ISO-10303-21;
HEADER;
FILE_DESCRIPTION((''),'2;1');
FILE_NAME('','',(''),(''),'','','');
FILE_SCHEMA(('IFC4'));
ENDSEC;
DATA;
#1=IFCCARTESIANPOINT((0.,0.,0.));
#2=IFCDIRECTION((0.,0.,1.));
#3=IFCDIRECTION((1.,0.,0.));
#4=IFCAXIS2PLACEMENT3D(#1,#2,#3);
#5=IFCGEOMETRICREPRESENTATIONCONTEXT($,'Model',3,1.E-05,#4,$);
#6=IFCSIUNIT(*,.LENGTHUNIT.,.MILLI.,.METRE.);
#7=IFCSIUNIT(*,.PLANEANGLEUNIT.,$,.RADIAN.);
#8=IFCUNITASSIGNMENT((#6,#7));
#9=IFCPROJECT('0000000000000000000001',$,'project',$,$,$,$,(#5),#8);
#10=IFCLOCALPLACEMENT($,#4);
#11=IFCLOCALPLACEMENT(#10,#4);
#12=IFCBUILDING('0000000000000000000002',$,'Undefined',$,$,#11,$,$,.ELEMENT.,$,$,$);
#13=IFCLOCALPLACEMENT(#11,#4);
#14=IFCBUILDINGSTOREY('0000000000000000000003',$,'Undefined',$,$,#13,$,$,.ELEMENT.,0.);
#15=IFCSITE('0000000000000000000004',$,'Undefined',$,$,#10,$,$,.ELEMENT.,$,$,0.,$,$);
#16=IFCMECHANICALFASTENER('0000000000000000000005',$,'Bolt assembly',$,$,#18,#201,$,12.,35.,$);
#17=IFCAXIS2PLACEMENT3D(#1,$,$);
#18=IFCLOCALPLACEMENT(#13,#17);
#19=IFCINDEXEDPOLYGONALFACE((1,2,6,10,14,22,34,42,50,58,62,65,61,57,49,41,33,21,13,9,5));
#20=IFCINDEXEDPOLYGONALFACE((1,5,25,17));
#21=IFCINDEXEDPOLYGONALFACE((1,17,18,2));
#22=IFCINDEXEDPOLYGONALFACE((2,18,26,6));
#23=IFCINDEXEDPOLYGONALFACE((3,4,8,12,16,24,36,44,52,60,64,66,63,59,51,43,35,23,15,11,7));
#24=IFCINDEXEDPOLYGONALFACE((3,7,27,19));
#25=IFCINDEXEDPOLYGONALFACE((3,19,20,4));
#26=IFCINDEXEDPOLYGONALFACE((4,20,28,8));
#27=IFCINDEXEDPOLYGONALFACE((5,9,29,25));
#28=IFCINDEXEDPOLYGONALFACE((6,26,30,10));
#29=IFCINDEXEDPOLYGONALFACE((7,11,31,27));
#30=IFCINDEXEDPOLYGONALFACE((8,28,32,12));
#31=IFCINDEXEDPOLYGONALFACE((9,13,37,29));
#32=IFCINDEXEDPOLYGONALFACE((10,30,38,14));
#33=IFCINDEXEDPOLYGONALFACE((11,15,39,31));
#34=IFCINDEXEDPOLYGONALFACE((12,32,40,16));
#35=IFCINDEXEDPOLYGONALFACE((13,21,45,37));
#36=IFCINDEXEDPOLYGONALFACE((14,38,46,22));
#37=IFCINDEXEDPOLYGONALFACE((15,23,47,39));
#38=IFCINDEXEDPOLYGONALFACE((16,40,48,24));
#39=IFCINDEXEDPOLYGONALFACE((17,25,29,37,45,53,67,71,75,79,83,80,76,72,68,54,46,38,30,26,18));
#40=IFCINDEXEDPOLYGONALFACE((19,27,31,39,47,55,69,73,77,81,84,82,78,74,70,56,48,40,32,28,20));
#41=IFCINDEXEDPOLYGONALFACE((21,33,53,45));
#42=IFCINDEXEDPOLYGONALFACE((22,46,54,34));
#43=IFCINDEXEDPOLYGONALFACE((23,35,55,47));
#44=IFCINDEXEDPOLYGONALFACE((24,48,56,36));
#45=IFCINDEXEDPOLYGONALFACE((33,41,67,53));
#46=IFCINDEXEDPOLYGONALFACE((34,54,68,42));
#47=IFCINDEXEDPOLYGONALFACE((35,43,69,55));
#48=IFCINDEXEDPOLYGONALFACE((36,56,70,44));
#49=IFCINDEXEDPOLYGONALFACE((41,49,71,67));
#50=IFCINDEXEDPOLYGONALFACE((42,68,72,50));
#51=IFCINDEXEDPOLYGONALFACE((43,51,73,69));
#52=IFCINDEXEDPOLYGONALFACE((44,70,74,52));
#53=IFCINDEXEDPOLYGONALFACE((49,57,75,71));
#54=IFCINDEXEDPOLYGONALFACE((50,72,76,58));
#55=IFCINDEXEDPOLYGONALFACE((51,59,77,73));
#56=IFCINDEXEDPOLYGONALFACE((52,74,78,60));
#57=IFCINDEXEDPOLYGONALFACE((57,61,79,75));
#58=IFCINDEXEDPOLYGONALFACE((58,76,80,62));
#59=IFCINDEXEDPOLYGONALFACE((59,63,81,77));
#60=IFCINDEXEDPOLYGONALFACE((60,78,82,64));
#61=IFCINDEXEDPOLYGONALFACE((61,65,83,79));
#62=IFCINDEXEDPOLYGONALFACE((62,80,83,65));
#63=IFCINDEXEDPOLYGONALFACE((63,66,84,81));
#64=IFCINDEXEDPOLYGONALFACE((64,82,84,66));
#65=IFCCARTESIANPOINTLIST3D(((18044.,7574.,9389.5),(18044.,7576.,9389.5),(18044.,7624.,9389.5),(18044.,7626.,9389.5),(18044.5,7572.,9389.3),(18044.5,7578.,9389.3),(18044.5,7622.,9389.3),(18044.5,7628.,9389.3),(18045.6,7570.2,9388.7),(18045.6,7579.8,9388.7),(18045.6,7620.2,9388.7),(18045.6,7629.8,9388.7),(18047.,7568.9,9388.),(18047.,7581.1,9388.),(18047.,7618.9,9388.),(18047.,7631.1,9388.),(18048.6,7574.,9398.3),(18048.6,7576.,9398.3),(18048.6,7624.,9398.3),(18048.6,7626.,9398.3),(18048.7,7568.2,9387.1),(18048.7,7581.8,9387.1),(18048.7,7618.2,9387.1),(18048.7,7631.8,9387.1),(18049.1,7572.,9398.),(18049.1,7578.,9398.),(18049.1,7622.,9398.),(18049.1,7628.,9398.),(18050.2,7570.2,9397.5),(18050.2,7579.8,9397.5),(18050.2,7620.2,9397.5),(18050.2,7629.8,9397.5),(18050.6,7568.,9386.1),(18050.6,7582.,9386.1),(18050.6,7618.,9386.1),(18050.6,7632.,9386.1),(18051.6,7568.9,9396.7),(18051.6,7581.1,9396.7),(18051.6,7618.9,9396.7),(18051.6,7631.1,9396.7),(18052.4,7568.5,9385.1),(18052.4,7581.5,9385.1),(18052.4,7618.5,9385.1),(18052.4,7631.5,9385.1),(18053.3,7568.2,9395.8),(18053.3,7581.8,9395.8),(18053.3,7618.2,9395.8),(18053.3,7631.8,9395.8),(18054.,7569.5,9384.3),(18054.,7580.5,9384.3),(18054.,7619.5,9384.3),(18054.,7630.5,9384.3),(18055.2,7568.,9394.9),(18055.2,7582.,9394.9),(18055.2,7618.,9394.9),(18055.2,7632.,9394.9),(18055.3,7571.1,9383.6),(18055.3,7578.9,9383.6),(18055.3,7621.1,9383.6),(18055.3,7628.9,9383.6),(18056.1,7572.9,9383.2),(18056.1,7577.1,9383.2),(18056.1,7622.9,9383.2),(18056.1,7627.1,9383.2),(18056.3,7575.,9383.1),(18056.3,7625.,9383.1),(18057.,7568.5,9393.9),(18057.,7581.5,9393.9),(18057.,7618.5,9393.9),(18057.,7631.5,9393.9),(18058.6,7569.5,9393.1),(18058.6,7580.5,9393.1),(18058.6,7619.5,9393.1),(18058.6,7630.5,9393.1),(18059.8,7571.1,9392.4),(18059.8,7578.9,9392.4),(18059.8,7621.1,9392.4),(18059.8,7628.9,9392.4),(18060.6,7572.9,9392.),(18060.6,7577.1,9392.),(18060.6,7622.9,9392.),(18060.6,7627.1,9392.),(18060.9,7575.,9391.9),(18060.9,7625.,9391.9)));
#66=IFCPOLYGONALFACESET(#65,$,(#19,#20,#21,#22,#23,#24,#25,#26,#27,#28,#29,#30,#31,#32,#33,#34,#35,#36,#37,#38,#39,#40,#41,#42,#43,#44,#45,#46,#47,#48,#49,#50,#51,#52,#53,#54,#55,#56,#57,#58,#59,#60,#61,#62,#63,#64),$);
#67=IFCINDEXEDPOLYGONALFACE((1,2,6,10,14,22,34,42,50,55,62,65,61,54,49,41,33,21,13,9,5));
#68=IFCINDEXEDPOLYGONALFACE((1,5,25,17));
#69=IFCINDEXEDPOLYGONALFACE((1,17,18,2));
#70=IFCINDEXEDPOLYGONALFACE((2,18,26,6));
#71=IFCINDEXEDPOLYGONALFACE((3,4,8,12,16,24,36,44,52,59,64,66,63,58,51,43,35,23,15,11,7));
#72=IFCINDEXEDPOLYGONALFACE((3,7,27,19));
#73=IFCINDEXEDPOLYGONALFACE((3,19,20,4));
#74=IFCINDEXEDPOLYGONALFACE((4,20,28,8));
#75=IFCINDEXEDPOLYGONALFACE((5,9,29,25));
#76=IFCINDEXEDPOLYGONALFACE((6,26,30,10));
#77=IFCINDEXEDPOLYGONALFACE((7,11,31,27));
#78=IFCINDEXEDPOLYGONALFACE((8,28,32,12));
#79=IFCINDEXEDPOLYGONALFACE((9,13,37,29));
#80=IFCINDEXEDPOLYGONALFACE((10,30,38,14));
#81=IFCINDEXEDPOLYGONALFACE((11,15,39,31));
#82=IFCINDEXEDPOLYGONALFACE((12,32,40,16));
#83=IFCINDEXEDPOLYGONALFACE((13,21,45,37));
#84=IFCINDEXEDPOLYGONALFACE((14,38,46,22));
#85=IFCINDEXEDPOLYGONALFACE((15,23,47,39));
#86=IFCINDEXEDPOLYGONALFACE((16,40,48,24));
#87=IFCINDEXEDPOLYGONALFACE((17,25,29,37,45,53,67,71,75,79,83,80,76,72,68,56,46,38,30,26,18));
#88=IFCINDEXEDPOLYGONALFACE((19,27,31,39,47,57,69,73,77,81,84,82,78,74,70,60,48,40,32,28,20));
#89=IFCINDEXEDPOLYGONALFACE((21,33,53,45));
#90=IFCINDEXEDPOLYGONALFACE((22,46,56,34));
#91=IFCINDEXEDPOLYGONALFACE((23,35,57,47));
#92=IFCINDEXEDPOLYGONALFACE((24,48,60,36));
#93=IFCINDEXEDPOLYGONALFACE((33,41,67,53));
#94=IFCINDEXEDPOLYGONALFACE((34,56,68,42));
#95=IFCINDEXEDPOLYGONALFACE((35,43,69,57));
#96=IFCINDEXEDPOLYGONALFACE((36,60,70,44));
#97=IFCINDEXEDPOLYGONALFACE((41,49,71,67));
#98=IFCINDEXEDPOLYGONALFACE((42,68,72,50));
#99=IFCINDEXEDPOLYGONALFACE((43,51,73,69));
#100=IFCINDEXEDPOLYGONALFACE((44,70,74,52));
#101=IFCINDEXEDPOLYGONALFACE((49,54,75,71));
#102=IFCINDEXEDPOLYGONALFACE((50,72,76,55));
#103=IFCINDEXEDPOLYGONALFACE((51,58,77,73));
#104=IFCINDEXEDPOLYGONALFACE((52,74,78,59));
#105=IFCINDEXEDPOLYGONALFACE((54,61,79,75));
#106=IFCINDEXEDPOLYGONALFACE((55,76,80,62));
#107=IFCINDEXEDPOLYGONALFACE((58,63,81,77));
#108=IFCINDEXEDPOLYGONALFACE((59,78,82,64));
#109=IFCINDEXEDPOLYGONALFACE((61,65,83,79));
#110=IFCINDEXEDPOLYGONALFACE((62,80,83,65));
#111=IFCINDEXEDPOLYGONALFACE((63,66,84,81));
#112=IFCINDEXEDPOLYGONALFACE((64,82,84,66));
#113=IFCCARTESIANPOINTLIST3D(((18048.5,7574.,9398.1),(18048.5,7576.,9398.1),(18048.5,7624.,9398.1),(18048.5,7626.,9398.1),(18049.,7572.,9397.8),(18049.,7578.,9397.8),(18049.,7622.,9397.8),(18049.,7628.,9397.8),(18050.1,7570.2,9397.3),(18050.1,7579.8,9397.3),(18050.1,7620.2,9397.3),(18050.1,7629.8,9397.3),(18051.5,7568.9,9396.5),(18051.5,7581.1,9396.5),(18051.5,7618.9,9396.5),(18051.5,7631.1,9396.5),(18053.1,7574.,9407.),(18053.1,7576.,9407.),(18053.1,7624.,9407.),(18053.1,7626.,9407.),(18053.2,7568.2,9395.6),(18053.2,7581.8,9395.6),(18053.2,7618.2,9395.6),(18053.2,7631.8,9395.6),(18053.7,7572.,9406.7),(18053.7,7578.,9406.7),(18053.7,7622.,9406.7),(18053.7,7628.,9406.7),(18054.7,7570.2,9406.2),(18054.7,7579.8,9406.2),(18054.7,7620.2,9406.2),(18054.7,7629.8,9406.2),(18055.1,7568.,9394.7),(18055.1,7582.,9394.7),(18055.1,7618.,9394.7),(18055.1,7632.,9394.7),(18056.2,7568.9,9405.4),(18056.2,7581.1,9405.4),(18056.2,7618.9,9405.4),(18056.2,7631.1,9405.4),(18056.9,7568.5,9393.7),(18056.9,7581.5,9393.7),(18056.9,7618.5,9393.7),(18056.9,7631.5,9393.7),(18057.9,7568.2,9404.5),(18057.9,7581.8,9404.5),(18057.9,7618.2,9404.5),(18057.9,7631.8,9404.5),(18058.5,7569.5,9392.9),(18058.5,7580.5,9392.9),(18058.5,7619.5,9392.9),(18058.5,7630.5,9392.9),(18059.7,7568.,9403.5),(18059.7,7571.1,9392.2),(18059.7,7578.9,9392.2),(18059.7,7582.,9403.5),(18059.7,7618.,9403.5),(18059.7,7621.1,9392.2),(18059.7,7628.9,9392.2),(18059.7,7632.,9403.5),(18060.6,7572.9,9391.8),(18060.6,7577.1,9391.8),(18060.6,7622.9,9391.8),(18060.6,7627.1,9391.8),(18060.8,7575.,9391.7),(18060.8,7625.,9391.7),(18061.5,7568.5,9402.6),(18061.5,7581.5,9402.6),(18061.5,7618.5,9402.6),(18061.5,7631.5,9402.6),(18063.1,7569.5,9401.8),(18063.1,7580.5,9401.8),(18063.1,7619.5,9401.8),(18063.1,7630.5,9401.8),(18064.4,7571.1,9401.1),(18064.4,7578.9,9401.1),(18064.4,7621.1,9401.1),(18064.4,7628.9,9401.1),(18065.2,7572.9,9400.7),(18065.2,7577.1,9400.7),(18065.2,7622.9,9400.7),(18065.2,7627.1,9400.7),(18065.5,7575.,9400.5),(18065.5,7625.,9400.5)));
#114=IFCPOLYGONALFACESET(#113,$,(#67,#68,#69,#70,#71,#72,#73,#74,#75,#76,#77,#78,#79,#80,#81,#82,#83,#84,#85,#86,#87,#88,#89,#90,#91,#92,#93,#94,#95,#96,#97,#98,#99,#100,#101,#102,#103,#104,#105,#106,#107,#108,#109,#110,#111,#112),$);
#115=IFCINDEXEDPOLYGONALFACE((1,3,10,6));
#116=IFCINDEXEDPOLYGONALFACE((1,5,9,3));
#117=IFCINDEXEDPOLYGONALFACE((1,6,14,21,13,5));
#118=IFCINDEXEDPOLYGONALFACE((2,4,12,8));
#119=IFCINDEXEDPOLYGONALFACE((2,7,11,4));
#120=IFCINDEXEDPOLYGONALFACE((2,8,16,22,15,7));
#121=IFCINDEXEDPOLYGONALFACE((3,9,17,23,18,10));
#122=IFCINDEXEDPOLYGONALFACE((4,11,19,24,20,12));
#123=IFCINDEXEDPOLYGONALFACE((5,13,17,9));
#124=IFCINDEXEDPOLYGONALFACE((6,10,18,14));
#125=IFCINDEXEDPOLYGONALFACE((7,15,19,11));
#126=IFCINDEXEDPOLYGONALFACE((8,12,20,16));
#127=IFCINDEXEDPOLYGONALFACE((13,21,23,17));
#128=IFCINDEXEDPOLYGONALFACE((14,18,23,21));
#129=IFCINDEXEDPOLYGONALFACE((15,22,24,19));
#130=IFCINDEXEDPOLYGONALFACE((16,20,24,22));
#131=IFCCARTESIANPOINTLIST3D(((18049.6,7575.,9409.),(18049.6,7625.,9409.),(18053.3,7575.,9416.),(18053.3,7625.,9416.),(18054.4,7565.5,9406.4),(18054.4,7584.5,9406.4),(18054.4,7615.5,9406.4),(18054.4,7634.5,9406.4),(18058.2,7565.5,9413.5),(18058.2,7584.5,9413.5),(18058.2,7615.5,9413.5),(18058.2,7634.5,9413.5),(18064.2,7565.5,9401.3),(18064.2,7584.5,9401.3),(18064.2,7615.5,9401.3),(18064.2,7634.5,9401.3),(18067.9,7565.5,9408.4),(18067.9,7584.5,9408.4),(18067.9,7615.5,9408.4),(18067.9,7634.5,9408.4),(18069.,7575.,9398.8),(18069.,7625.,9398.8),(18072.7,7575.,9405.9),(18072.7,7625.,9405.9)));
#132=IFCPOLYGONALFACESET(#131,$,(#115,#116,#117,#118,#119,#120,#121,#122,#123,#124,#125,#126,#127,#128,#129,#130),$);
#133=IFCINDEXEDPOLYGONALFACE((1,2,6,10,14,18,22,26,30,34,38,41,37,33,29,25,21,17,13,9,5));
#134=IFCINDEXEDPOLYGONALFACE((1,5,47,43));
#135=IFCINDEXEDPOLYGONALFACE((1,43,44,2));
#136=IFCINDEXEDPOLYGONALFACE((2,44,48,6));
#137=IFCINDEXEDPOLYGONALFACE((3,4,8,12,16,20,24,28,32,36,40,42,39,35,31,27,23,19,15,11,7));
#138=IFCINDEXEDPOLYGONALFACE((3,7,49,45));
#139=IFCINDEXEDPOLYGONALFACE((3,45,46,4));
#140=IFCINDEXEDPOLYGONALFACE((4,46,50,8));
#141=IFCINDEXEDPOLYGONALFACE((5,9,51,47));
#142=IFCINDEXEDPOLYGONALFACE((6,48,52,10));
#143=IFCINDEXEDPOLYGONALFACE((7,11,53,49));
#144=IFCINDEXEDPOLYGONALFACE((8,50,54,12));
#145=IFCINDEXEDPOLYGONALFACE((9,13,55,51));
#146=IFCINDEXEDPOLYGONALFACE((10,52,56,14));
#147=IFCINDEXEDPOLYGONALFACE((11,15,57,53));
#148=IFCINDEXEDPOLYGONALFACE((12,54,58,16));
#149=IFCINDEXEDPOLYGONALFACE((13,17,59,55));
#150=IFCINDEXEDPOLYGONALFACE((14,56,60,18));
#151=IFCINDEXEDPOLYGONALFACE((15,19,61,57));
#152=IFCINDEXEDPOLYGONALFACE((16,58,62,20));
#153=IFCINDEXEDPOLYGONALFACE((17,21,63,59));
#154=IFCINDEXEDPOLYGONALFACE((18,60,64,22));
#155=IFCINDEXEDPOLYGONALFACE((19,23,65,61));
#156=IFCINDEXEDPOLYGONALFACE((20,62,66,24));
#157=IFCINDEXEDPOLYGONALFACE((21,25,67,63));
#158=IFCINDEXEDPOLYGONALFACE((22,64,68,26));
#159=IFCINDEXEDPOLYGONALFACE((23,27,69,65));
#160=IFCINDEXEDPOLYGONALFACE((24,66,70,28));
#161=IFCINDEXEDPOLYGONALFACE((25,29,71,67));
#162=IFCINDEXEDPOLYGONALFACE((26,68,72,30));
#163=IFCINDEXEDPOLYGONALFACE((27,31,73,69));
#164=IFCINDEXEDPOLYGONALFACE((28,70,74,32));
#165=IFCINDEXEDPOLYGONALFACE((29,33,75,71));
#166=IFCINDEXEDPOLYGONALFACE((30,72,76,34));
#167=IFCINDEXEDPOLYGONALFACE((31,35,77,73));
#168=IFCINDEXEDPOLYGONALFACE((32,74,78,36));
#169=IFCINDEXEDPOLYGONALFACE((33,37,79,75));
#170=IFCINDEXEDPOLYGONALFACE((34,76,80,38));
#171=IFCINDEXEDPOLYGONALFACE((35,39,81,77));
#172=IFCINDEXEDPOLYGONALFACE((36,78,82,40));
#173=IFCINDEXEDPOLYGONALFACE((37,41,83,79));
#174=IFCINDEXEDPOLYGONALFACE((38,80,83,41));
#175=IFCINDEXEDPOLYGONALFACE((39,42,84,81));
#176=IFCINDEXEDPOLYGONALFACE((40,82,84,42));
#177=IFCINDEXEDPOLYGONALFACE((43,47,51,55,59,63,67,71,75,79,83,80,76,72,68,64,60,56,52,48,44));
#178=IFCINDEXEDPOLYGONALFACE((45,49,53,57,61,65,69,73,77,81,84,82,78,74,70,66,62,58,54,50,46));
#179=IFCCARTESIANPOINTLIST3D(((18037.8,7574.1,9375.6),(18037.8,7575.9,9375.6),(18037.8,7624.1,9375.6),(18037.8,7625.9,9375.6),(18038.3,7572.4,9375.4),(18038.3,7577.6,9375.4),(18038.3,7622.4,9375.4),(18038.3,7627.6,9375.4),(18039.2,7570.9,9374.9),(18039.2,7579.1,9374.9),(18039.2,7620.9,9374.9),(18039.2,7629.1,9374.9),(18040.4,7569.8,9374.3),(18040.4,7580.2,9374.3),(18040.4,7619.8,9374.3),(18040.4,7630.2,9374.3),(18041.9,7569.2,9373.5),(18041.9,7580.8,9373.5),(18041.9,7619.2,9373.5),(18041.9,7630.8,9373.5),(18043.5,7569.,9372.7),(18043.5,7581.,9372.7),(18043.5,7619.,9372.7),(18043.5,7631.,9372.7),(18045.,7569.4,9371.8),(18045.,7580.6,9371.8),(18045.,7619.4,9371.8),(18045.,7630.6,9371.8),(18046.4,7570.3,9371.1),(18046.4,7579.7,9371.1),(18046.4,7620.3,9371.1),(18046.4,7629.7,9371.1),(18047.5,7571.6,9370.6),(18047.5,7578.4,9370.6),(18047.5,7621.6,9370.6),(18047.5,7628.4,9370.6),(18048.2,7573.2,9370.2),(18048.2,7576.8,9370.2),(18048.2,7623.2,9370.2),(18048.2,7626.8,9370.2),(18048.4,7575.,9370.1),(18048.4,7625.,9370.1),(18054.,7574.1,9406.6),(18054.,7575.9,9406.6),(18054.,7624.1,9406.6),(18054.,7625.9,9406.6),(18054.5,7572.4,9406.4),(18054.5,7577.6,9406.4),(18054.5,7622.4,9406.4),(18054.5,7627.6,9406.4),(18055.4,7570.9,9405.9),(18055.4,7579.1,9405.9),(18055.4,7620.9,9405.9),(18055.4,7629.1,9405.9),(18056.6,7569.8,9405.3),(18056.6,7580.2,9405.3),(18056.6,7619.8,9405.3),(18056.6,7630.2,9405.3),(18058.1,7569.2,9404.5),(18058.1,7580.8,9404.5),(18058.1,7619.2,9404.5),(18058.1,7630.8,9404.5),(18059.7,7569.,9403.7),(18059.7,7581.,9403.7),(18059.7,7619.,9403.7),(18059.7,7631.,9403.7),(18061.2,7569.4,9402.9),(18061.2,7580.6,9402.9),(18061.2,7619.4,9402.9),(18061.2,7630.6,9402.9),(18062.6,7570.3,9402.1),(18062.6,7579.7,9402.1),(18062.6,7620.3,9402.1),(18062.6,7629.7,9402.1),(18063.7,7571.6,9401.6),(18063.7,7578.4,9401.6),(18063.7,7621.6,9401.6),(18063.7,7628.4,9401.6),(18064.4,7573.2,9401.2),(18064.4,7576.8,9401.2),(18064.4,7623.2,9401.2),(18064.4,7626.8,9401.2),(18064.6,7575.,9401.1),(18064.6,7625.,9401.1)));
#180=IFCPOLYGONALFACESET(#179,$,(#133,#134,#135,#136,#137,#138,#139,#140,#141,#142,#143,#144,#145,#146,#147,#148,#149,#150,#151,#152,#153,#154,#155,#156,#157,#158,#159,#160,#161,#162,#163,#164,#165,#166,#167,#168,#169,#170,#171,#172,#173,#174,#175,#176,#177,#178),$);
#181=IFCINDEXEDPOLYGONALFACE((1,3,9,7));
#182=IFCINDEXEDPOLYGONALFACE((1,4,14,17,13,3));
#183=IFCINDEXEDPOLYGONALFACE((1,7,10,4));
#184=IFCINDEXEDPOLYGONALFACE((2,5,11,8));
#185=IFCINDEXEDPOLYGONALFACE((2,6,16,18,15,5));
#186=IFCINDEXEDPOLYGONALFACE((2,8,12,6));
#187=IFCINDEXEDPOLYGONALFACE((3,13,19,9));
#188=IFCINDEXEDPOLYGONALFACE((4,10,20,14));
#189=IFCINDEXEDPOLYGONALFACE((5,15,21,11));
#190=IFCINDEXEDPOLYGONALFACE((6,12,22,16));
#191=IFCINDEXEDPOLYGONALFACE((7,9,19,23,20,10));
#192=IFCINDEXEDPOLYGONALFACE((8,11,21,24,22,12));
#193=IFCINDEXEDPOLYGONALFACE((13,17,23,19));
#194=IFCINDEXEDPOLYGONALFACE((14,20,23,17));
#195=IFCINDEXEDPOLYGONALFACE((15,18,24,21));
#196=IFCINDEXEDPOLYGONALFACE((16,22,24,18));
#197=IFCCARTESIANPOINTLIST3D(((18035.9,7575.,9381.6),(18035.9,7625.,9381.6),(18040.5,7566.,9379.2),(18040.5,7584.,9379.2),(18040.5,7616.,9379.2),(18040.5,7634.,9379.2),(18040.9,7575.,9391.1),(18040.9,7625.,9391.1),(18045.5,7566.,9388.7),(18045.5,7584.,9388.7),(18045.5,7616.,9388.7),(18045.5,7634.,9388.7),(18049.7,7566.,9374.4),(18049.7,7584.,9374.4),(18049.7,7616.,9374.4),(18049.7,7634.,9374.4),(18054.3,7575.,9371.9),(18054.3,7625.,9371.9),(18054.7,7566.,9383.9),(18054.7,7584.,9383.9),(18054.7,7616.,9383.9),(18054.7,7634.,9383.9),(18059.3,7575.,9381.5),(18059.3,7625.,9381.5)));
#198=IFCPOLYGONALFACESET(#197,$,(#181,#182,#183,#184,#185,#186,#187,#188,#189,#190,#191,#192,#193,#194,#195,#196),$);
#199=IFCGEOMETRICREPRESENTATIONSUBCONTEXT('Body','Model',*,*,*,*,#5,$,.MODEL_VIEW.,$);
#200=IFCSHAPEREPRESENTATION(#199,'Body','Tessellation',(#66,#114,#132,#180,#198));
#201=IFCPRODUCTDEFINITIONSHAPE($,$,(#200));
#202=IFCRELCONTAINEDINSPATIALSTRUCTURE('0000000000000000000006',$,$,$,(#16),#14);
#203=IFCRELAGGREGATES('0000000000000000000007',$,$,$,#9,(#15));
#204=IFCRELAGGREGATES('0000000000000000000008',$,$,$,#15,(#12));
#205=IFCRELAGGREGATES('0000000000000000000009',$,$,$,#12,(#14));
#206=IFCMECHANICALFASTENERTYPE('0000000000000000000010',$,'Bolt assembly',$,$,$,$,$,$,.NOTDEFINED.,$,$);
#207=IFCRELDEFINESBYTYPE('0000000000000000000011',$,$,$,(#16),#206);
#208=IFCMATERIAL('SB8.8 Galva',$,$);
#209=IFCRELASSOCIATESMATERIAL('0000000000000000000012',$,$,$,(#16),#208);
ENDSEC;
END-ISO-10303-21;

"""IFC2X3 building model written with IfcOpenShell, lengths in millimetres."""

from ifc_helpers import new_model, si_unit, frame, origin_with_axes, origin_2d_with_axis, place, context, subcontext, project, spatial, polyline, circle, outline, extrude, source, transform, mapped, material, type_object, element, save


model = new_model("IFC2X3")

# Units and contexts
model_context = context("Model", 3, precision=1e-05, world=origin_with_axes())
body_context = subcontext(model_context, "Body", "Model", "MODEL_VIEW")
ifc_project = project(units=[si_unit("LENGTHUNIT", "METRE", prefix="MILLI"), si_unit("PLANEANGLEUNIT", "RADIAN")], contexts=[model_context])

# Site, building, storey
site_placement = place(None, origin_with_axes())
site = spatial("IfcSite", under=ifc_project, at=site_placement, Name="Undefined", CompositionType="ELEMENT", RefElevation=0.0)
building_placement = place(site_placement, origin_with_axes())
building = spatial("IfcBuilding", under=site, at=building_placement, Name="Undefined", CompositionType="ELEMENT")
storey_placement = place(building_placement, origin_with_axes())
storey = spatial("IfcBuildingStorey", under=building, at=storey_placement, Name="Undefined", CompositionType="ELEMENT", Elevation=0.0)

# Mechanical fastener
mechanical_fastener_type = type_object("IfcMechanicalFastenerType", Name="Bolt assembly")
ifc_material_1 = material(Name="SB8.8 Galva")
shared_shape_1 = source(origin_with_axes(), body_context, "Body", "SweptSolid", [
    extrude(circle(Radius=7.0, at=origin_2d_with_axis()), frame((0.0, -0.1, 0.0), z_axis=(0.0, 1.0, 0.0), x_axis=(1.0, 0.0, 0.0)), (0.0, 0.0, 1.0), 9.9),
    extrude(circle(Radius=7.0, at=origin_2d_with_axis()), frame((0.0, -9.9, 0.0), z_axis=(0.0, 1.0, 0.0), x_axis=(1.0, 0.0, 0.0)), (0.0, 0.0, 1.0), 10.0),
    extrude(outline(polyline([(11.0, 0.0), (5.5, 9.5), (-5.5, 9.5), (-11.0, 0.0), (-5.5, -9.5), (5.5, -9.5), (11.0, 0.0)])), frame((0.0, -18.0, 0.0), z_axis=(0.0, 1.0, 0.0), x_axis=(1.0, 0.0, 0.0)), (0.0, 0.0, 1.0), 8.0),
    extrude(circle(Radius=6.0, at=origin_2d_with_axis()), frame((0.0, -10.0, 0.0), z_axis=(0.0, 1.0, 0.0), x_axis=(1.0, 0.0, 0.0)), (0.0, 0.0, 1.0), 35.0),
    extrude(outline(polyline([(10.4, 0.0), (5.2, 9.0), (-5.2, 9.0), (-10.4, 0.0), (-5.2, -9.0), (5.2, -9.0), (10.4, 0.0)])), frame((0.0, 9.8, 0.0), z_axis=(0.0, 1.0, 0.0), x_axis=(1.0, 0.0, 0.0)), (0.0, 0.0, 1.0), 10.8),
])
for number, where, z_axis, x_axis, name in (
    (1, (18054.7, 7600.0, 9395.0), (0.0, 1.0, 0.0), (0.886082, 0.0, -0.463529), "Bolt assembly"),
):
    element("IfcMechanicalFastener", number, at=place(storey_placement, frame(where, z_axis=z_axis, x_axis=x_axis)), inside=storey, type_object=mechanical_fastener_type, material=ifc_material_1, Name=name, NominalDiameter=12.0, NominalLength=35.0, context=body_context, shape_type="MappedRepresentation", body=[
        mapped(shared_shape_1, transform((0.0, 0.0, -25.0))),
        mapped(shared_shape_1, transform((0.0, 0.0, 25.0))),
    ])

save(model, "model.ifc")
